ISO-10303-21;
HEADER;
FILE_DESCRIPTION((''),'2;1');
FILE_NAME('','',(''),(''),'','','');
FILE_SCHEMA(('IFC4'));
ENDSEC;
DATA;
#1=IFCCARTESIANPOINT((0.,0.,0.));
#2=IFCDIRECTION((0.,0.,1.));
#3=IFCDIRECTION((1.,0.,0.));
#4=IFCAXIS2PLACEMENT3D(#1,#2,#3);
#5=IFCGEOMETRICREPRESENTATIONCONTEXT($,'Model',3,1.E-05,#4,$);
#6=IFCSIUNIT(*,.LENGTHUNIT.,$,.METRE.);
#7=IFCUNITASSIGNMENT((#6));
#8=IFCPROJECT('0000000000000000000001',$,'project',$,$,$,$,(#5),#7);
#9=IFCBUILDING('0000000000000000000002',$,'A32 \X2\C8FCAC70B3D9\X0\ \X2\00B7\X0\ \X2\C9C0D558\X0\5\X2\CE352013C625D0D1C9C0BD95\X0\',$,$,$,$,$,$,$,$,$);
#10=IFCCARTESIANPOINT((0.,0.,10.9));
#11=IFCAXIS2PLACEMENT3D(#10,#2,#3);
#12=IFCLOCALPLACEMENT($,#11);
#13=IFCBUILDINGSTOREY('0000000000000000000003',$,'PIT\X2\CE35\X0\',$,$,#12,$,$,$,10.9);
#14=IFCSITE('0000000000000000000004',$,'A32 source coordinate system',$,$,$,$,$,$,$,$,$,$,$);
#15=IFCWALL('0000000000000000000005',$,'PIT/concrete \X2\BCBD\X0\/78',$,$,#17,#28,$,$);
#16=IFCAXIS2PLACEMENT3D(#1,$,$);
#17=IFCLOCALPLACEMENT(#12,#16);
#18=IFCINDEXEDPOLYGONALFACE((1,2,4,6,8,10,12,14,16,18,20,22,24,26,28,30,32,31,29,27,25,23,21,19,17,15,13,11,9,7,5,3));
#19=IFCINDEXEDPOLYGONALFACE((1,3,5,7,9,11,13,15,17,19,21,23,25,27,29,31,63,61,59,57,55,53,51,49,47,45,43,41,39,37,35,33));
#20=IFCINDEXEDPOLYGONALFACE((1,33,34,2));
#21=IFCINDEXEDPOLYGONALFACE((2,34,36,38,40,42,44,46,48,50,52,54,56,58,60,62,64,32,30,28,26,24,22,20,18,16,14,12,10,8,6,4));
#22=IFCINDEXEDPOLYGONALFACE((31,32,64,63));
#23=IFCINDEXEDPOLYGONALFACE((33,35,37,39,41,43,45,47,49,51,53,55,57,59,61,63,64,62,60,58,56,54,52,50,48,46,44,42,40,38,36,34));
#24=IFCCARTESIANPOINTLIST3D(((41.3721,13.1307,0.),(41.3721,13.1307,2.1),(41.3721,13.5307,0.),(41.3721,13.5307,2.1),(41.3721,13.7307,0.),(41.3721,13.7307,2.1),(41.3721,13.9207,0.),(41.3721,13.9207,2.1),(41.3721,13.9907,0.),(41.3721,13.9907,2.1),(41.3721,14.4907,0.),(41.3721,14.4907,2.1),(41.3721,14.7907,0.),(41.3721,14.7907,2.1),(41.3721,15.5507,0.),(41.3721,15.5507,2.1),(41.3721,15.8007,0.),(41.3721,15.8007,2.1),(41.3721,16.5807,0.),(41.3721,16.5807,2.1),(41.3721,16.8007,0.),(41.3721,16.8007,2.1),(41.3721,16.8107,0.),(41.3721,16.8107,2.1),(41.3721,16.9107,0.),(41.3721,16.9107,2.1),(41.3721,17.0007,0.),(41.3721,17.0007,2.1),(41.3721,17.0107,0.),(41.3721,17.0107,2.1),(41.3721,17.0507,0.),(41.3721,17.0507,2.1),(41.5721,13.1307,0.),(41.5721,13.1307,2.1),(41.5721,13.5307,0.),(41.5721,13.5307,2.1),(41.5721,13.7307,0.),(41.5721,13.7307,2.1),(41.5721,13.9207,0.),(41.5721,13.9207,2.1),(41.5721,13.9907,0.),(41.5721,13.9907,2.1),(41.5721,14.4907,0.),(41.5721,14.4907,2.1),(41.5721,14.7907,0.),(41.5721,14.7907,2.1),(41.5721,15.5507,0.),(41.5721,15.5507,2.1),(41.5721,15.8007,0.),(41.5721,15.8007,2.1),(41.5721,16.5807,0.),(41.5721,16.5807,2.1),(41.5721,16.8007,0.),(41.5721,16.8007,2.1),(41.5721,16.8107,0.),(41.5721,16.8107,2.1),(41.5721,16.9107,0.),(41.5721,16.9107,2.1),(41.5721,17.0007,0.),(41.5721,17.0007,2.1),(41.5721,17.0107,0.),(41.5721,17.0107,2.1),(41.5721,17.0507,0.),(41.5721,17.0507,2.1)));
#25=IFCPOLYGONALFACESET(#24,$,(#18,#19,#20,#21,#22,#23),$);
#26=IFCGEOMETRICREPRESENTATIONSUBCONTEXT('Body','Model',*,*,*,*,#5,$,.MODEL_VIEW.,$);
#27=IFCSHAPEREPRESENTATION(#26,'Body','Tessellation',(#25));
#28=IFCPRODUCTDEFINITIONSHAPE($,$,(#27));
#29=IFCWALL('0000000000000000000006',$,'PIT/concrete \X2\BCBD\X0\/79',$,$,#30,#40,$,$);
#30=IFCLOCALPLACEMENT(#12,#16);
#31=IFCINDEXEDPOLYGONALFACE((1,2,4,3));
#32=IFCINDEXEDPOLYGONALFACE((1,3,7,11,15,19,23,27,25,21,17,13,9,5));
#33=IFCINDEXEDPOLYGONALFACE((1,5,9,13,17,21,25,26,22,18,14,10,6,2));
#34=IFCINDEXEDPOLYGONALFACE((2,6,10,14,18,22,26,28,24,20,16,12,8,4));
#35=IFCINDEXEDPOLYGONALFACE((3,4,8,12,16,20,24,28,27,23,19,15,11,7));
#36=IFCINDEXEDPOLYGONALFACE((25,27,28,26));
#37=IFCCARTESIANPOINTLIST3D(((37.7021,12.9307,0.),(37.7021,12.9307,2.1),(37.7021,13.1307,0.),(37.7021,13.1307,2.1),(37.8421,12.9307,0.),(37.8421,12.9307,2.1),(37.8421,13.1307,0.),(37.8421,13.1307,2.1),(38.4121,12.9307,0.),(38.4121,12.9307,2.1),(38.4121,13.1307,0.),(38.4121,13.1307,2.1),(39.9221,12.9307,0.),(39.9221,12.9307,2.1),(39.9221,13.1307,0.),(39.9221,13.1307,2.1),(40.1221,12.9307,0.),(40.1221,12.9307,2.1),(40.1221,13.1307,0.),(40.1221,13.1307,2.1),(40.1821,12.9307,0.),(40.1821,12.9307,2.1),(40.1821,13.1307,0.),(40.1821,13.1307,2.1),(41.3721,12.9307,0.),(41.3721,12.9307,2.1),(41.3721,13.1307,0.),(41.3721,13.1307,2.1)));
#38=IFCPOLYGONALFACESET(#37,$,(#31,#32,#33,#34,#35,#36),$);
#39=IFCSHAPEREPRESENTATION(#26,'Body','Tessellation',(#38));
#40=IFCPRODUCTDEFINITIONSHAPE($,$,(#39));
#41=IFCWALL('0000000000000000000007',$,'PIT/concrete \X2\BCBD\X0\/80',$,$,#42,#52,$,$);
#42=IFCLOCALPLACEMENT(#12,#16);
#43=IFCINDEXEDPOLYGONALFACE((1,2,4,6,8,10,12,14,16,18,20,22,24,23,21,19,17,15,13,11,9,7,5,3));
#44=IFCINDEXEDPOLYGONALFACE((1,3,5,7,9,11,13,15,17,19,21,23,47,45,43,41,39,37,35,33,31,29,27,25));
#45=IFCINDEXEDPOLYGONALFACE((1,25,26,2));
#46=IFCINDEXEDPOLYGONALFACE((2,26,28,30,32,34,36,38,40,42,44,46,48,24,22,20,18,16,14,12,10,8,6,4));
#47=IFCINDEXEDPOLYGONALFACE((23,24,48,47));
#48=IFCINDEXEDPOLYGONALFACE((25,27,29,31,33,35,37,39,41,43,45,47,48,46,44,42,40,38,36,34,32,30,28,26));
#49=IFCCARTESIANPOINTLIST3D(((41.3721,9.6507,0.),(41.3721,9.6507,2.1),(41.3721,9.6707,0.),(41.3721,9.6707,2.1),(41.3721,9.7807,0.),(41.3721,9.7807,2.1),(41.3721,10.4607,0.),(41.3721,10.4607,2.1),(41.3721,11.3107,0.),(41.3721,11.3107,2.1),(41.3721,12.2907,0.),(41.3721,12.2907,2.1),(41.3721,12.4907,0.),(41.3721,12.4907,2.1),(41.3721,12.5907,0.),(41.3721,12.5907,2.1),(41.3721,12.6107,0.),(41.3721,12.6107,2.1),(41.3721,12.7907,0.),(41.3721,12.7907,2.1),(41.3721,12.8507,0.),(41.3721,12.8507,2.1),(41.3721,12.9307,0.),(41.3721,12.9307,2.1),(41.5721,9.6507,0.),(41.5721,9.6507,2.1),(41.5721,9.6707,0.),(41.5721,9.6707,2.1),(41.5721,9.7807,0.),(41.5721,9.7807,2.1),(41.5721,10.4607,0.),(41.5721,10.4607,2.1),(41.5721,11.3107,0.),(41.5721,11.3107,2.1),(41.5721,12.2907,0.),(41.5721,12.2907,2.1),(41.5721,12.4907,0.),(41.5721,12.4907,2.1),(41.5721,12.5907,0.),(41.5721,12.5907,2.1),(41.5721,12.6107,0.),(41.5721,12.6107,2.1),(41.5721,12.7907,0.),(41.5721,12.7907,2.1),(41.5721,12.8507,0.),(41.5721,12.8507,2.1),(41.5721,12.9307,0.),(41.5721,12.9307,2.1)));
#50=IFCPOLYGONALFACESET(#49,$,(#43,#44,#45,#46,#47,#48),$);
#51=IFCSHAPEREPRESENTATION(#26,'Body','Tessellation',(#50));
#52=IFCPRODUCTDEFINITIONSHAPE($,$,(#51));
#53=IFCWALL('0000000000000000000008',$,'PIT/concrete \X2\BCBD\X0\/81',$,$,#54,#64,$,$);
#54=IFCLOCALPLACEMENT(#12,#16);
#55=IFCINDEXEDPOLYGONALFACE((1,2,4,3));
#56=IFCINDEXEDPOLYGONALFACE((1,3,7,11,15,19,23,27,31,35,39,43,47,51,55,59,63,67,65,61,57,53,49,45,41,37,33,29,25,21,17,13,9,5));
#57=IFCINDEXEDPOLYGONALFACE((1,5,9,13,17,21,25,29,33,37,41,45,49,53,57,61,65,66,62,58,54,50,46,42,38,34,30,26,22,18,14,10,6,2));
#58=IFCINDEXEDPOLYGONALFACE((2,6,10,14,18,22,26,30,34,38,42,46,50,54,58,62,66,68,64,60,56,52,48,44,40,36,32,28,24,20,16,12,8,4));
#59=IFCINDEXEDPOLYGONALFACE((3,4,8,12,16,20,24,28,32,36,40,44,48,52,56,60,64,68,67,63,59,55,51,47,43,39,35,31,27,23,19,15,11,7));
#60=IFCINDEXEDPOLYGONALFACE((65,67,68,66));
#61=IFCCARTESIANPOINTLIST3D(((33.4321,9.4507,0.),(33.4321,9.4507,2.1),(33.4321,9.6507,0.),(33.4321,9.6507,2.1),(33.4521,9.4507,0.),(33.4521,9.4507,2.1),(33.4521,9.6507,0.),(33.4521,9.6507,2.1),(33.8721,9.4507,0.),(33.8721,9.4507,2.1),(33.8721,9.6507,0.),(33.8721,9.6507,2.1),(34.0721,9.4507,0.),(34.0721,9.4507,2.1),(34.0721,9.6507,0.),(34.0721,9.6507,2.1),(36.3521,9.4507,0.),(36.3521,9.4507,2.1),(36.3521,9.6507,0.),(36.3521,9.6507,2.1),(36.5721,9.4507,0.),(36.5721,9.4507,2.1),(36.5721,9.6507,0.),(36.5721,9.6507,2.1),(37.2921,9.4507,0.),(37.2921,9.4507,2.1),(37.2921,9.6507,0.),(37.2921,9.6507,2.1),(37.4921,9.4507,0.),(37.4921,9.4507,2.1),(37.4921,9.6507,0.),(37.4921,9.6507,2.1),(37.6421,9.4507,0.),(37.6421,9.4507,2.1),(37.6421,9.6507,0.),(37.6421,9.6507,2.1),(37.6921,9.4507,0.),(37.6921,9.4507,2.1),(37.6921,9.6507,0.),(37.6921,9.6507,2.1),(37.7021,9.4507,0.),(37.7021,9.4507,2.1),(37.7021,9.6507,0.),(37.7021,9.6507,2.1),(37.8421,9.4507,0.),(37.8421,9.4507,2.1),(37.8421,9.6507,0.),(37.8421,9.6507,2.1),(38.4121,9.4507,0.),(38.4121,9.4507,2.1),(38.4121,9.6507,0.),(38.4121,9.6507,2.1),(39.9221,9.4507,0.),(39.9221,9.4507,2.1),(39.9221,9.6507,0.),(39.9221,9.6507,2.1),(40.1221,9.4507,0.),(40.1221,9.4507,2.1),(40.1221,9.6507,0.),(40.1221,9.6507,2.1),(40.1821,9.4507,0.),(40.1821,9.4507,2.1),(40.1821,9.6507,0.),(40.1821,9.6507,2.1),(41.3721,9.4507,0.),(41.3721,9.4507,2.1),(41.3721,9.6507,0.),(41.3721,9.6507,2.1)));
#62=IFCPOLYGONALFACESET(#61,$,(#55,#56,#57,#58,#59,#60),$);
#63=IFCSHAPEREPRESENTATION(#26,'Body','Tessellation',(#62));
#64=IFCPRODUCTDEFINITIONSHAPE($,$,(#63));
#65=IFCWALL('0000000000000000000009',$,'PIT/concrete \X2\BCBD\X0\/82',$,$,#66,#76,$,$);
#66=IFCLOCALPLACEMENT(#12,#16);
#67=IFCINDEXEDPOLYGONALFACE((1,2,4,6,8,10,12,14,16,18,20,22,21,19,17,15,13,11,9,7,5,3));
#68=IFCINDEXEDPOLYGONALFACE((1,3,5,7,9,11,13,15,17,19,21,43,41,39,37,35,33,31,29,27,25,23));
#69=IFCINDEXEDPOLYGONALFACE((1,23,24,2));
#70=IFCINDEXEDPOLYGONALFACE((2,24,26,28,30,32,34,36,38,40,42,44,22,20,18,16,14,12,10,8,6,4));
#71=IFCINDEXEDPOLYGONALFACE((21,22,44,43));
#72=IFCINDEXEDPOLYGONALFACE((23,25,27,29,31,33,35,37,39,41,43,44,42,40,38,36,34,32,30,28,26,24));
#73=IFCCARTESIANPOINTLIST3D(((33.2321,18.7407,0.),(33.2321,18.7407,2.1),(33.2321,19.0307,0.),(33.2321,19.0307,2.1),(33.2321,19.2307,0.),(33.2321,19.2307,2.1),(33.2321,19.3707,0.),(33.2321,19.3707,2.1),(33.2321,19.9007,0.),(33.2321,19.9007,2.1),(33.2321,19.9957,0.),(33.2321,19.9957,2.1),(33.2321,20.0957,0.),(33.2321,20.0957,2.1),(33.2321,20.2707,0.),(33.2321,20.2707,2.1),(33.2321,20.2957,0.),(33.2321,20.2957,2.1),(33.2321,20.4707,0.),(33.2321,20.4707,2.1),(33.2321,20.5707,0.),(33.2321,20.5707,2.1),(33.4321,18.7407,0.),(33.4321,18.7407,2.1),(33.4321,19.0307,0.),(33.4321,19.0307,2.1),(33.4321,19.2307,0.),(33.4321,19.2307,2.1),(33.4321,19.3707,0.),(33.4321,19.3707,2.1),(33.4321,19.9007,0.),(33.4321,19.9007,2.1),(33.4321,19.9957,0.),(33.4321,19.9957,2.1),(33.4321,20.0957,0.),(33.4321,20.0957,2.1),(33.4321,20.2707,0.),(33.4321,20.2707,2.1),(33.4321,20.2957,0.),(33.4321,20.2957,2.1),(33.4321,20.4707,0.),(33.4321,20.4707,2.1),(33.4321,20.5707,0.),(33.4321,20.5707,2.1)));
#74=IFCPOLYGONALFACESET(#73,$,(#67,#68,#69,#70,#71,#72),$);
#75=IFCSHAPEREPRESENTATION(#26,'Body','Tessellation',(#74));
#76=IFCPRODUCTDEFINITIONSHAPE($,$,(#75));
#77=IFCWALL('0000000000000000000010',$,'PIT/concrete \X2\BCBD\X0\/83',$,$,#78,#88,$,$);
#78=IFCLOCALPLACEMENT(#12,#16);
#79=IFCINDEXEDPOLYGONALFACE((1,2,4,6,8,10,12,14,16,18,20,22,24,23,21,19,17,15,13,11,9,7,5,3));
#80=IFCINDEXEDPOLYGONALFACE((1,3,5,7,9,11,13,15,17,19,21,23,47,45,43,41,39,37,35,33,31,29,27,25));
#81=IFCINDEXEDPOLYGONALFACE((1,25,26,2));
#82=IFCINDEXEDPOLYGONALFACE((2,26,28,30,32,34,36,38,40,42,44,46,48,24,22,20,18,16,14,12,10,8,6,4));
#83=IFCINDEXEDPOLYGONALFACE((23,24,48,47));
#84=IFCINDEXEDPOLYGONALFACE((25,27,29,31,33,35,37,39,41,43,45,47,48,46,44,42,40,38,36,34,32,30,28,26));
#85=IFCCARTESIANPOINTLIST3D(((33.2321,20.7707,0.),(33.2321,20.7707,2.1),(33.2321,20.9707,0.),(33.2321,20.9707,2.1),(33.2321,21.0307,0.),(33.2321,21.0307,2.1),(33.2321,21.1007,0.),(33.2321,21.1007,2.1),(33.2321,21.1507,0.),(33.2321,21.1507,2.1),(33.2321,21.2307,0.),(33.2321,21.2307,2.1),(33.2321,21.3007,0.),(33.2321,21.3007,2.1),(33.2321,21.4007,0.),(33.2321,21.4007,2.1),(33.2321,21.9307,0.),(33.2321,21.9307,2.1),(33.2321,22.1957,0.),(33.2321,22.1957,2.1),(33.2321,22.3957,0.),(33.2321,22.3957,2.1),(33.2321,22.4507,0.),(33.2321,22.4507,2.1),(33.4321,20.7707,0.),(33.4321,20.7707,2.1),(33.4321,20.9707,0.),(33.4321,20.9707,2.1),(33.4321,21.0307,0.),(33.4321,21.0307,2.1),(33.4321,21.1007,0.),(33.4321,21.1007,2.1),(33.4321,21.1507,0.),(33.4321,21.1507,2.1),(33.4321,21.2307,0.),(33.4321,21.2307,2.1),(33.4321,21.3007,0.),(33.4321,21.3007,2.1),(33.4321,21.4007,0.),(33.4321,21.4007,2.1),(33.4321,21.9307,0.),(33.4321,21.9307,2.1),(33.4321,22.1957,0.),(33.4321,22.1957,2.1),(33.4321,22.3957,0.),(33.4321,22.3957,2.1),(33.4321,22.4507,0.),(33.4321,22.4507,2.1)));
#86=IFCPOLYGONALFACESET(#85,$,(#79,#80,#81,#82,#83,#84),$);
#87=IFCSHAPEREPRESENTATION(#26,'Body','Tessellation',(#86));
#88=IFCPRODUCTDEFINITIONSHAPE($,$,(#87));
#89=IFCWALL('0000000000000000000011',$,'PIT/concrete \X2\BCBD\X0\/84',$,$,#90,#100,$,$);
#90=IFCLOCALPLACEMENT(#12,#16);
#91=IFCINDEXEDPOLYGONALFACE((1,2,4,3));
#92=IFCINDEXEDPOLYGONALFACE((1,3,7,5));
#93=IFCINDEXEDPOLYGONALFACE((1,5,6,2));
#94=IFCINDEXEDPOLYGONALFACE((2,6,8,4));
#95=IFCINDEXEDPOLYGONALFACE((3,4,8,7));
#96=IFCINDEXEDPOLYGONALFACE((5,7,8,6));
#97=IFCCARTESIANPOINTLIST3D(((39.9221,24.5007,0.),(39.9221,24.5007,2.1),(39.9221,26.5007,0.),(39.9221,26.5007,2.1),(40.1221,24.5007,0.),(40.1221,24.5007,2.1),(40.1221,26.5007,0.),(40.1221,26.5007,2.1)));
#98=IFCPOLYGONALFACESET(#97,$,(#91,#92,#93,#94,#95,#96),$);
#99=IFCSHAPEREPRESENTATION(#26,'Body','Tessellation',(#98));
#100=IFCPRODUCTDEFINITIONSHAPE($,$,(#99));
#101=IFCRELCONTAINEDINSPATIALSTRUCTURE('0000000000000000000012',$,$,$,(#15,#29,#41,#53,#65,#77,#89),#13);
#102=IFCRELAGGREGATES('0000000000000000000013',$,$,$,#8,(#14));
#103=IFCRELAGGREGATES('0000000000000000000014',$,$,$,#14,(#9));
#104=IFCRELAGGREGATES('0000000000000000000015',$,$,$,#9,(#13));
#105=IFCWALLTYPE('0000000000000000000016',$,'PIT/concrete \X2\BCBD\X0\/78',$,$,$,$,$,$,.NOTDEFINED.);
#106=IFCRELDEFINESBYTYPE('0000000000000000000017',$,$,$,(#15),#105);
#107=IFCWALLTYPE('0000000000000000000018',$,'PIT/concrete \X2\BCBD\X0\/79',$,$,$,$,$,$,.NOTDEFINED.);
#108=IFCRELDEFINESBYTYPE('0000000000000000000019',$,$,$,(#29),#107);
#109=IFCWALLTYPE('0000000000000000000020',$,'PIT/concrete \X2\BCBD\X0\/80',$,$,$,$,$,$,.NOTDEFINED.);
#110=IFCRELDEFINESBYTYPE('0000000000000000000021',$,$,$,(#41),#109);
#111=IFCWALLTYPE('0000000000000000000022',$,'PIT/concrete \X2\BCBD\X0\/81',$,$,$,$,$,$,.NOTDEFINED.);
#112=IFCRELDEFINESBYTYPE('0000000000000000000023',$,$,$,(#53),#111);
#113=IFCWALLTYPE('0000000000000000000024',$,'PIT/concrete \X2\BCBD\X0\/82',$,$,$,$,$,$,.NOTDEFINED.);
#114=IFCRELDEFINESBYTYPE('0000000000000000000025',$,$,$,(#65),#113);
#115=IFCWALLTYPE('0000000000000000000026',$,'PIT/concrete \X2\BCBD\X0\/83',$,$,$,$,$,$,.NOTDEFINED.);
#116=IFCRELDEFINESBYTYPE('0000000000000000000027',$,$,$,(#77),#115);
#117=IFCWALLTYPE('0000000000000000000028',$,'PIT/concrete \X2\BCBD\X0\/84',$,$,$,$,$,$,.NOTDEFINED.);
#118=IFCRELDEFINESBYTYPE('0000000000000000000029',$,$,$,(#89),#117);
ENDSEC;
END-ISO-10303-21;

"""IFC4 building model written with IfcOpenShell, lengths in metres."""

from ifc_helpers import new_model, si_unit, frame, origin, origin_with_axes, place, context, subcontext, project, spatial, polyline, outline, extrude, source, transform, mapped, type_object, type_shapes, element, save


model = new_model("IFC4")

# Units and contexts
model_context = context("Model", 3, precision=1e-05, world=origin_with_axes())
body_context = subcontext(model_context, "Body", "Model", "MODEL_VIEW")
ifc_project = project(units=[si_unit("LENGTHUNIT", "METRE")], contexts=[model_context])

# Site, building, storey
site = spatial("IfcSite", under=ifc_project, Name="A32 source coordinate system")
building = spatial("IfcBuilding", under=site, Name="A32 주거동 · 지하5층–옥탑지붕")
storey_placement = place(None, frame((0.0, 0.0, 10.9), z_axis=(0.0, 0.0, 1.0), x_axis=(1.0, 0.0, 0.0)))
storey = spatial("IfcBuildingStorey", under=building, at=storey_placement, Name="PIT층", Elevation=10.9)

# Walls
wall_type_1 = type_object("IfcWallType", Name="PIT/concrete 벽/78", PredefinedType="NOTDEFINED")
shared_shape_1 = source(origin(), body_context, "Body", "SweptSolid", [
    extrude(outline(polyline([(41.5721, 17.0007), (41.5721, 16.9107), (41.5721, 16.8107), (41.5721, 16.8007), (41.5721, 16.5807), (41.5721, 15.8007), (41.5721, 15.5507), (41.5721, 14.7907), (41.5721, 14.4907), (41.5721, 13.9907), (41.5721, 13.9207), (41.5721, 13.7307), (41.5721, 13.5307), (41.5721, 13.1307), (41.3721, 13.1307), (41.3721, 13.5307), (41.3721, 13.7307), (41.3721, 13.9207), (41.3721, 13.9907), (41.3721, 14.4907), (41.3721, 14.7907), (41.3721, 15.5507), (41.3721, 15.8007), (41.3721, 16.5807), (41.3721, 16.8007), (41.3721, 16.8107), (41.3721, 16.9107), (41.3721, 17.0007), (41.3721, 17.0107), (41.3721, 17.0507), (41.5721, 17.0507), (41.5721, 17.0107), (41.5721, 17.0007)])), origin(), (0.0, 0.0, 1.0), 2.1),
])
type_shapes(wall_type_1, [shared_shape_1])
wall_1_placement = place(storey_placement, origin_with_axes())
element("IfcWall", 1, at=wall_1_placement, inside=storey, type_object=wall_type_1, Name="PIT/concrete 벽/78", context=body_context, shape_type="MappedRepresentation", body=[
    mapped(shared_shape_1, transform((0.0, 0.0, 0.0), scale=1.0)),
])
wall_type_2 = type_object("IfcWallType", Name="PIT/concrete 벽/79", PredefinedType="NOTDEFINED")
shared_shape_2 = source(origin(), body_context, "Body", "SweptSolid", [
    extrude(outline(polyline([(40.1221, 12.9307), (39.9221, 12.9307), (38.4121, 12.9307), (37.8421, 12.9307), (37.7021, 12.9307), (37.7021, 13.1307), (37.8421, 13.1307), (38.4121, 13.1307), (39.9221, 13.1307), (40.1221, 13.1307), (40.1821, 13.1307), (41.3721, 13.1307), (41.3721, 12.9307), (40.1821, 12.9307), (40.1221, 12.9307)])), origin(), (0.0, 0.0, 1.0), 2.1),
])
type_shapes(wall_type_2, [shared_shape_2])
wall_2_placement = place(storey_placement, origin_with_axes())
element("IfcWall", 2, at=wall_2_placement, inside=storey, type_object=wall_type_2, Name="PIT/concrete 벽/79", context=body_context, shape_type="MappedRepresentation", body=[
    mapped(shared_shape_2, transform((0.0, 0.0, 0.0), scale=1.0)),
])
wall_type_3 = type_object("IfcWallType", Name="PIT/concrete 벽/80", PredefinedType="NOTDEFINED")
shared_shape_3 = source(origin(), body_context, "Body", "SweptSolid", [
    extrude(outline(polyline([(41.5721, 12.7907), (41.5721, 12.6107), (41.5721, 12.5907), (41.5721, 12.4907), (41.5721, 12.2907), (41.5721, 11.3107), (41.5721, 10.4607), (41.5721, 9.7807), (41.5721, 9.6707), (41.5721, 9.6507), (41.3721, 9.6507), (41.3721, 9.6707), (41.3721, 9.7807), (41.3721, 10.4607), (41.3721, 11.3107), (41.3721, 12.2907), (41.3721, 12.4907), (41.3721, 12.5907), (41.3721, 12.6107), (41.3721, 12.7907), (41.3721, 12.8507), (41.3721, 12.9307), (41.5721, 12.9307), (41.5721, 12.8507), (41.5721, 12.7907)])), origin(), (0.0, 0.0, 1.0), 2.1),
])
type_shapes(wall_type_3, [shared_shape_3])
wall_3_placement = place(storey_placement, origin_with_axes())
element("IfcWall", 3, at=wall_3_placement, inside=storey, type_object=wall_type_3, Name="PIT/concrete 벽/80", context=body_context, shape_type="MappedRepresentation", body=[
    mapped(shared_shape_3, transform((0.0, 0.0, 0.0), scale=1.0)),
])
wall_type_4 = type_object("IfcWallType", Name="PIT/concrete 벽/81", PredefinedType="NOTDEFINED")
shared_shape_4 = source(origin(), body_context, "Body", "SweptSolid", [
    extrude(outline(polyline([(40.1221, 9.4507), (39.9221, 9.4507), (38.4121, 9.4507), (37.8421, 9.4507), (37.7021, 9.4507), (37.6921, 9.4507), (37.6421, 9.4507), (37.4921, 9.4507), (37.2921, 9.4507), (36.5721, 9.4507), (36.3521, 9.4507), (34.0721, 9.4507), (33.8721, 9.4507), (33.4521, 9.4507), (33.4321, 9.4507), (33.4321, 9.6507), (33.4521, 9.6507), (33.8721, 9.6507), (34.0721, 9.6507), (36.3521, 9.6507), (36.5721, 9.6507), (37.2921, 9.6507), (37.4921, 9.6507), (37.6421, 9.6507), (37.6921, 9.6507), (37.7021, 9.6507), (37.8421, 9.6507), (38.4121, 9.6507), (39.9221, 9.6507), (40.1221, 9.6507), (40.1821, 9.6507), (41.3721, 9.6507), (41.3721, 9.4507), (40.1821, 9.4507), (40.1221, 9.4507)])), origin(), (0.0, 0.0, 1.0), 2.1),
])
type_shapes(wall_type_4, [shared_shape_4])
wall_4_placement = place(storey_placement, origin_with_axes())
element("IfcWall", 4, at=wall_4_placement, inside=storey, type_object=wall_type_4, Name="PIT/concrete 벽/81", context=body_context, shape_type="MappedRepresentation", body=[
    mapped(shared_shape_4, transform((0.0, 0.0, 0.0), scale=1.0)),
])
wall_type_5 = type_object("IfcWallType", Name="PIT/concrete 벽/82", PredefinedType="NOTDEFINED")
shared_shape_5 = source(origin(), body_context, "Body", "SweptSolid", [
    extrude(outline(polyline([(33.4321, 20.2707), (33.4321, 20.0957), (33.4321, 19.9957), (33.4321, 19.9007), (33.4321, 19.3707), (33.4321, 19.2307), (33.4321, 19.0307), (33.4321, 18.7407), (33.2321, 18.7407), (33.2321, 19.0307), (33.2321, 19.2307), (33.2321, 19.3707), (33.2321, 19.9007), (33.2321, 19.9957), (33.2321, 20.0957), (33.2321, 20.2707), (33.2321, 20.2957), (33.2321, 20.4707), (33.2321, 20.5707), (33.4321, 20.5707), (33.4321, 20.4707), (33.4321, 20.2957), (33.4321, 20.2707)])), origin(), (0.0, 0.0, 1.0), 2.1),
])
type_shapes(wall_type_5, [shared_shape_5])
wall_5_placement = place(storey_placement, origin_with_axes())
element("IfcWall", 5, at=wall_5_placement, inside=storey, type_object=wall_type_5, Name="PIT/concrete 벽/82", context=body_context, shape_type="MappedRepresentation", body=[
    mapped(shared_shape_5, transform((0.0, 0.0, 0.0), scale=1.0)),
])
wall_type_6 = type_object("IfcWallType", Name="PIT/concrete 벽/83", PredefinedType="NOTDEFINED")
shared_shape_6 = source(origin(), body_context, "Body", "SweptSolid", [
    extrude(outline(polyline([(33.2321, 21.0307), (33.2321, 21.1007), (33.2321, 21.1507), (33.2321, 21.2307), (33.2321, 21.3007), (33.2321, 21.4007), (33.2321, 21.9307), (33.2321, 22.1957), (33.2321, 22.3957), (33.2321, 22.4507), (33.4321, 22.4507), (33.4321, 22.3957), (33.4321, 22.1957), (33.4321, 21.9307), (33.4321, 21.4007), (33.4321, 21.3007), (33.4321, 21.2307), (33.4321, 21.1507), (33.4321, 21.1007), (33.4321, 21.0307), (33.4321, 20.9707), (33.4321, 20.7707), (33.2321, 20.7707), (33.2321, 20.9707), (33.2321, 21.0307)])), origin(), (0.0, 0.0, 1.0), 2.1),
])
type_shapes(wall_type_6, [shared_shape_6])
wall_6_placement = place(storey_placement, origin_with_axes())
element("IfcWall", 6, at=wall_6_placement, inside=storey, type_object=wall_type_6, Name="PIT/concrete 벽/83", context=body_context, shape_type="MappedRepresentation", body=[
    mapped(shared_shape_6, transform((0.0, 0.0, 0.0), scale=1.0)),
])
wall_type_7 = type_object("IfcWallType", Name="PIT/concrete 벽/84", PredefinedType="NOTDEFINED")
shared_shape_7 = source(origin(), body_context, "Body", "SweptSolid", [
    extrude(outline(polyline([(40.1221, 26.5007), (40.1221, 24.5007), (39.9221, 24.5007), (39.9221, 26.5007), (40.1221, 26.5007)])), origin(), (0.0, 0.0, 1.0), 2.1),
])
type_shapes(wall_type_7, [shared_shape_7])
wall_7_placement = place(storey_placement, origin_with_axes())
element("IfcWall", 7, at=wall_7_placement, inside=storey, type_object=wall_type_7, Name="PIT/concrete 벽/84", context=body_context, shape_type="MappedRepresentation", body=[
    mapped(shared_shape_7, transform((0.0, 0.0, 0.0), scale=1.0)),
])

save(model, "model.ifc")
